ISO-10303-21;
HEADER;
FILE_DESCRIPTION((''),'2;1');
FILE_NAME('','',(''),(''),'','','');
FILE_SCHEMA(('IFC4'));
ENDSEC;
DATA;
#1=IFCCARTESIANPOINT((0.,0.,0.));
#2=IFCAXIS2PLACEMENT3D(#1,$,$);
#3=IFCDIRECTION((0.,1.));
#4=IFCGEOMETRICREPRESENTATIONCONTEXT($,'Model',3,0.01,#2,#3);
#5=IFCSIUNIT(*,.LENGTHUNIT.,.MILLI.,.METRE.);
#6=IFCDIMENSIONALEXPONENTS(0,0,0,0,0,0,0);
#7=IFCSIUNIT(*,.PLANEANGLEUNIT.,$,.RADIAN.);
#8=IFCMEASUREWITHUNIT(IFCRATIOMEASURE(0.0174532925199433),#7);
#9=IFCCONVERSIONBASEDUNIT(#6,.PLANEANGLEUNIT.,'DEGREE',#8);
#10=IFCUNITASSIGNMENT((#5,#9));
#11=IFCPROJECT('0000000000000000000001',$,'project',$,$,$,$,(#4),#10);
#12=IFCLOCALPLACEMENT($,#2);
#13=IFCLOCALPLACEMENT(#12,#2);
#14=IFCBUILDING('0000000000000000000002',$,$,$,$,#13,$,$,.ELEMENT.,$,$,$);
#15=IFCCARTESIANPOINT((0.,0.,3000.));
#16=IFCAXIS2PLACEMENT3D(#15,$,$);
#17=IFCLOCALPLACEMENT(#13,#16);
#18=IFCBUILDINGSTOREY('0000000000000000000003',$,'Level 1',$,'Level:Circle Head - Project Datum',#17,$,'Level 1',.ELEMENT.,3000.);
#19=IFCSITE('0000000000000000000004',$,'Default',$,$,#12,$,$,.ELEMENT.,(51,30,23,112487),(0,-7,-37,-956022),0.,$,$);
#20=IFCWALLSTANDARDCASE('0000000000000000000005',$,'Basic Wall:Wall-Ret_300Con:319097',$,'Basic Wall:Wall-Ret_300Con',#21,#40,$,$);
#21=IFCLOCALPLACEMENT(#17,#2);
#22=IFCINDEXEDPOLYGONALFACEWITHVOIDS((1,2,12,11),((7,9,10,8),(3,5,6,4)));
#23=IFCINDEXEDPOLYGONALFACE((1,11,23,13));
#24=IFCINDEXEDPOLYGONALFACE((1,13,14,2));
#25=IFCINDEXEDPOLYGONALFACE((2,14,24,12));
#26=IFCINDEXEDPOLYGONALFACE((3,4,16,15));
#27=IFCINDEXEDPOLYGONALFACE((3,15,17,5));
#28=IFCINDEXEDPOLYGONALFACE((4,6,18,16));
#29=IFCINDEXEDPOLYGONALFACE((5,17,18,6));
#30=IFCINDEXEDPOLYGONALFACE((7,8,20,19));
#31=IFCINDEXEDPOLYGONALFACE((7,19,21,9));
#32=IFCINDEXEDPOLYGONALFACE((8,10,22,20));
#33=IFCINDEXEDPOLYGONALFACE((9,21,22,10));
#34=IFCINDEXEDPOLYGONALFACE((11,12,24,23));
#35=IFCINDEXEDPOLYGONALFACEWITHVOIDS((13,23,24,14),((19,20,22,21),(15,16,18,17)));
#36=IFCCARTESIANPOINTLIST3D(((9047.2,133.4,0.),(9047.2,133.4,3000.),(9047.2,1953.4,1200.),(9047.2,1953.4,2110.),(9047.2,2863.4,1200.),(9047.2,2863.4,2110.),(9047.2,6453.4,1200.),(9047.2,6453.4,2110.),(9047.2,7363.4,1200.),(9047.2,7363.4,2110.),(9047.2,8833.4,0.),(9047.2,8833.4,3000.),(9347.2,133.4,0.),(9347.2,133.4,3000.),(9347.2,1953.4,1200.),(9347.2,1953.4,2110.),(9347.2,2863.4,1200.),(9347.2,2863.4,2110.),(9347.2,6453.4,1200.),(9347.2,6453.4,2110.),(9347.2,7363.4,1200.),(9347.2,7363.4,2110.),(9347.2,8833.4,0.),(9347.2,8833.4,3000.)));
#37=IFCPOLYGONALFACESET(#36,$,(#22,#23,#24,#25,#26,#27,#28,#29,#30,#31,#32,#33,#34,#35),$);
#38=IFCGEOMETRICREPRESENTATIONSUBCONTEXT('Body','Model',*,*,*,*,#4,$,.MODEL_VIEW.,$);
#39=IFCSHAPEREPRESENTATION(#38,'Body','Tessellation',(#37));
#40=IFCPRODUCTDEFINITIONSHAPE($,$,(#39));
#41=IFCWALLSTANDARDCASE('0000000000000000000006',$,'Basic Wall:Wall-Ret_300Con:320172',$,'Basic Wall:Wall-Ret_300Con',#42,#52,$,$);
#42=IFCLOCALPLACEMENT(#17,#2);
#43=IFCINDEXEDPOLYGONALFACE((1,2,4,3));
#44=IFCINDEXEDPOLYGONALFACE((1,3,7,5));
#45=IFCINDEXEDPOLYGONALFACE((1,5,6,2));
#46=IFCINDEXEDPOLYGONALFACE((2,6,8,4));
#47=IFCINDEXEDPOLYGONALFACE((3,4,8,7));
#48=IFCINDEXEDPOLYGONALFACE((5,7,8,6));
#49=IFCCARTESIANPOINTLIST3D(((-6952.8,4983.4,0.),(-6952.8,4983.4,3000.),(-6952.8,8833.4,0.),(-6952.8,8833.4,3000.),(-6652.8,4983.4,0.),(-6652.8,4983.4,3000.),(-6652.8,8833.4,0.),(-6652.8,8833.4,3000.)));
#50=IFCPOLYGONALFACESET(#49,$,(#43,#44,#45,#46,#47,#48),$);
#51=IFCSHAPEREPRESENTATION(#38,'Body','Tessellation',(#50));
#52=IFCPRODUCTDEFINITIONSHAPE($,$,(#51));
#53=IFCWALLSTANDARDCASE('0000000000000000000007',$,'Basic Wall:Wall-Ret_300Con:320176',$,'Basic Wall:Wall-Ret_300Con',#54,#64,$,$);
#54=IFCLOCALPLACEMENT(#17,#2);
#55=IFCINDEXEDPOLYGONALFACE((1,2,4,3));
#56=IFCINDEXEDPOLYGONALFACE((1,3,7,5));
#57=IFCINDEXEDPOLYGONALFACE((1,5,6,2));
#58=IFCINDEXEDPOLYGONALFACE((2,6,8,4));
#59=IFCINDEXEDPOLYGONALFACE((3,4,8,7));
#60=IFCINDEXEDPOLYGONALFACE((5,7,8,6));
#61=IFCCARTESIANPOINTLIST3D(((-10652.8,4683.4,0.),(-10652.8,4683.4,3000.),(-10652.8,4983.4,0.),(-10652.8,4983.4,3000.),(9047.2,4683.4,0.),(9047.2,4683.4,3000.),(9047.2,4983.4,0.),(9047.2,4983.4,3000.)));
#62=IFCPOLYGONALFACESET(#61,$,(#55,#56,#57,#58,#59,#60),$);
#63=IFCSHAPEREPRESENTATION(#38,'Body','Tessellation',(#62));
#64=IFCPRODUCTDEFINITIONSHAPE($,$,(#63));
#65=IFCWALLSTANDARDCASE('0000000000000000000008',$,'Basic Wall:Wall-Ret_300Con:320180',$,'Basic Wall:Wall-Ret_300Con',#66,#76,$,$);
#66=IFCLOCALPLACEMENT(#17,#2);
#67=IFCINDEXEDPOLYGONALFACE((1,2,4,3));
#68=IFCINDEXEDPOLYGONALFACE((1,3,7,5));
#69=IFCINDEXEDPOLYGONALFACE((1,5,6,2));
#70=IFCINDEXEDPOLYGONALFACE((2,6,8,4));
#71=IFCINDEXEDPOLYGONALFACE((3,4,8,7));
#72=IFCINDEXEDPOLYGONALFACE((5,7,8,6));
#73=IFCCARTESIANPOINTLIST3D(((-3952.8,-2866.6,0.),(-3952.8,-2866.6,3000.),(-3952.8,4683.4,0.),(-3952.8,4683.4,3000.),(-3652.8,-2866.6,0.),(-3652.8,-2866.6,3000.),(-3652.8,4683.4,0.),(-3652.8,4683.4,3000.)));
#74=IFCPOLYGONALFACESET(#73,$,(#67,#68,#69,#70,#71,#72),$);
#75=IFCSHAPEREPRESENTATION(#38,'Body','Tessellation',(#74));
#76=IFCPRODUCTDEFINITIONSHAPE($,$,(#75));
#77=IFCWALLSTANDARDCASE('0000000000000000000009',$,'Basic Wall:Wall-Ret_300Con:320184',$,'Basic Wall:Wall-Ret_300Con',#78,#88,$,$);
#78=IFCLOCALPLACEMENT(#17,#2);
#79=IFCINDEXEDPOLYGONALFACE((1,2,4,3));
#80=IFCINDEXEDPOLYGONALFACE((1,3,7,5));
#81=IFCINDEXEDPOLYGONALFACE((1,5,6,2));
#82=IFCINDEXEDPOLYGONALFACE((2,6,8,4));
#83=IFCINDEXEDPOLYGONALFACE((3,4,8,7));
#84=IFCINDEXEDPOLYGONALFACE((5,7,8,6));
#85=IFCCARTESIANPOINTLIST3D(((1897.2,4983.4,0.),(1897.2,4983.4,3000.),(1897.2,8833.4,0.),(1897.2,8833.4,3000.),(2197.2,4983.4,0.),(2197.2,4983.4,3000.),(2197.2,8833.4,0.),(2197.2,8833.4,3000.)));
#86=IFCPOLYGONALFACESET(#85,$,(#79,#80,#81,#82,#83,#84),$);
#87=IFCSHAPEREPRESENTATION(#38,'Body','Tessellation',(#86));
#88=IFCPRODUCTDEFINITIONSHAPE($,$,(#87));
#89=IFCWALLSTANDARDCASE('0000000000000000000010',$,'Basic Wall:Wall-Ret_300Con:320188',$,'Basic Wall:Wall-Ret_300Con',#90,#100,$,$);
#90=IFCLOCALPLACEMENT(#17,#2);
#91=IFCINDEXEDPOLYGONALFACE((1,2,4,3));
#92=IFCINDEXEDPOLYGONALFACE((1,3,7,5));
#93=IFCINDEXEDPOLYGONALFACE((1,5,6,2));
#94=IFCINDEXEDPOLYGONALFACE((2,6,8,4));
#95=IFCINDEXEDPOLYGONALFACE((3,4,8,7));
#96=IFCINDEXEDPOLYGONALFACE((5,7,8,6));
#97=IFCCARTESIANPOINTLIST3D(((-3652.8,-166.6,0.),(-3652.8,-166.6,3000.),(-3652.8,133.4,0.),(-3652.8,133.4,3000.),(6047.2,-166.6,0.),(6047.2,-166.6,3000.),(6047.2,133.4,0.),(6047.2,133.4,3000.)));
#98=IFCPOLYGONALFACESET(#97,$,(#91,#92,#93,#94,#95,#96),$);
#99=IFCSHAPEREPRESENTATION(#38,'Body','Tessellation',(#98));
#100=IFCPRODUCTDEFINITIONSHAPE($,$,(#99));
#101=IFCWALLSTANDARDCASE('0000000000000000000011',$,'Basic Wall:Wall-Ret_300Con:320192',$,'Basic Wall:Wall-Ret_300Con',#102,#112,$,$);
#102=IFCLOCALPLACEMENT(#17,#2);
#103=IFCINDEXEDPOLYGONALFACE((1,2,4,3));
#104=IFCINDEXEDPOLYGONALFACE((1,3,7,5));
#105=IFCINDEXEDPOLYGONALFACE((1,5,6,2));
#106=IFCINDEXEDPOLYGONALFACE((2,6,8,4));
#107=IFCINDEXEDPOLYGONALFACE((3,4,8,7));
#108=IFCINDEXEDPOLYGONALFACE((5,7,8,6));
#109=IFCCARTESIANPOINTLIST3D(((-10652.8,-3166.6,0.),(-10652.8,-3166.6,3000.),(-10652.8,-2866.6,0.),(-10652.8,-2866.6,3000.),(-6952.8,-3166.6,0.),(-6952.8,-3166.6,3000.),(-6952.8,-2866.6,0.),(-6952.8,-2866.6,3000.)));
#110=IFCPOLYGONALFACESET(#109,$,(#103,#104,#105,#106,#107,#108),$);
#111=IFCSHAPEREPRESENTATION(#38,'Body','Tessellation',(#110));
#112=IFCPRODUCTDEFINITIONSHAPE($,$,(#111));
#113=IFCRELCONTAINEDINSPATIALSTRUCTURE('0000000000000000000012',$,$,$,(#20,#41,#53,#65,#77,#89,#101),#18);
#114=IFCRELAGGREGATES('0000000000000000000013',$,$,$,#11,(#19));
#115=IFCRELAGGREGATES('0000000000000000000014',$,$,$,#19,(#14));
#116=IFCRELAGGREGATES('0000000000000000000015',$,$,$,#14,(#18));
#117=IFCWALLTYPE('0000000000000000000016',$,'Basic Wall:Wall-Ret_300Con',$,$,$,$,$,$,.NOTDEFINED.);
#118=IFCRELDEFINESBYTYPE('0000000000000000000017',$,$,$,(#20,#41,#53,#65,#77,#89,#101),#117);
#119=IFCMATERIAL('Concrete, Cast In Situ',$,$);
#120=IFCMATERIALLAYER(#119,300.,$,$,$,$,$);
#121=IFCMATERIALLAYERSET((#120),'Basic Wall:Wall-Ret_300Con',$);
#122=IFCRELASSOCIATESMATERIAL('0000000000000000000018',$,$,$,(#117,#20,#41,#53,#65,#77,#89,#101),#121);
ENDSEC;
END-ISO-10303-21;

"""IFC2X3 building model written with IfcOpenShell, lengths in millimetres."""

from ifc_helpers import new_model, entity, si_unit, converted_unit, direction, frame, frame_2d, origin, place, context, subcontext, project, spatial, rectangle, extrude, material, layer, layer_set, layer_usage, type_object, element, save


model = new_model("IFC2X3")

# Units and contexts
model_context = context("Model", 3, precision=0.01, world=origin(), true_north=direction((0.0, 1.0)))
body_context = subcontext(model_context, "Body", "Model", "MODEL_VIEW")
ifc_project = project(units=[si_unit("LENGTHUNIT", "METRE", prefix="MILLI"), converted_unit("PLANEANGLEUNIT", "DEGREE", entity("IfcRatioMeasure", 0.0174532925199433), si_unit("PLANEANGLEUNIT", "RADIAN"), dimensions=[0, 0, 0, 0, 0, 0, 0])], contexts=[model_context])

# Site, building, storey
site_placement = place(None, origin())
site = spatial("IfcSite", under=ifc_project, at=site_placement, Name="Default", CompositionType="ELEMENT", RefLatitude=(51, 30, 23, 112487), RefLongitude=(0, -7, -37, -956022), RefElevation=0.0)
building_placement = place(site_placement, origin())
building = spatial("IfcBuilding", under=site, at=building_placement, CompositionType="ELEMENT")
storey_placement = place(building_placement, frame((0.0, 0.0, 3000.0)))
storey = spatial("IfcBuildingStorey", under=building, at=storey_placement, Name="Level 1", ObjectType="Level:Circle Head - Project Datum", LongName="Level 1", CompositionType="ELEMENT", Elevation=3000.0)

# Shared definitions
ifc_material_1 = material(Name="Concrete, Cast In Situ")
ifc_layer_1 = layer(ifc_material_1, 300.0)
ifc_layer_set_1 = layer_set([ifc_layer_1], Name="Basic Wall:Wall-Ret_300Con")
wall_type = type_object("IfcWallType", Name="Basic Wall:Wall-Ret_300Con", PredefinedType="NOTDEFINED", material=ifc_layer_set_1)

# Wall, openings
ifc_layer_usage_1 = layer_usage(ifc_layer_set_1, "AXIS2", "NEGATIVE", 150.0)
wall_1_placement = place(storey_placement, frame((9197.2, 8833.4, 0.0), z_axis=(0.0, 0.0, 1.0), x_axis=(0.0, -1.0, 0.0)))
wall_1 = element("IfcWallStandardCase", 1, at=wall_1_placement, inside=storey, type_object=wall_type, material=ifc_layer_usage_1, Name="Basic Wall:Wall-Ret_300Con:319097", ObjectType="Basic Wall:Wall-Ret_300Con", context=body_context, shape_type="SweptSolid", body=[
    extrude(rectangle(XDim=8700.0, YDim=300.0, at=frame_2d((4350.0, 0.0), x_axis=(-1.0, 0.0))), origin(), (0.0, 0.0, 1.0), 3000.0),
])
opening_1_placement = place(wall_1_placement, frame((5970.0, -150.0, 1200.0)))
element("IfcOpeningElement", 2, at=opening_1_placement, cuts=wall_1, ObjectType="Opening", context=body_context, shape_type="SweptSolid", body=[
    extrude(rectangle(XDim=910.0, YDim=910.0, at=frame_2d((455.0, 455.0), x_axis=(-1.0, 0.0))), frame((0.0, 0.0, 0.0), z_axis=(0.0, 1.0, 0.0), x_axis=(0.0, 0.0, 1.0)), (0.0, 0.0, 1.0), 300.0),
])
opening_2_placement = place(wall_1_placement, frame((2380.0, 150.0, 1200.0)))
element("IfcOpeningElement", 3, at=opening_2_placement, cuts=wall_1, ObjectType="Opening", context=body_context, shape_type="SweptSolid", body=[
    extrude(rectangle(XDim=910.0, YDim=910.0, at=frame_2d((455.0, 455.0), x_axis=(-1.0, 0.0))), frame((0.0, 0.0, 0.0), z_axis=(0.0, -1.0, 0.0), x_axis=(0.0, 0.0, 1.0)), (0.0, 0.0, 1.0), 300.0),
])

# Walls
ifc_layer_usage_2 = layer_usage(ifc_layer_set_1, "AXIS2", "NEGATIVE", 150.0)
wall_2_placement = place(storey_placement, frame((-6802.8, 4983.4, 0.0), z_axis=(0.0, 0.0, 1.0), x_axis=(0.0, 1.0, 0.0)))
element("IfcWallStandardCase", 4, at=wall_2_placement, inside=storey, type_object=wall_type, material=ifc_layer_usage_2, Name="Basic Wall:Wall-Ret_300Con:320172", ObjectType="Basic Wall:Wall-Ret_300Con", context=body_context, shape_type="SweptSolid", body=[
    extrude(rectangle(XDim=3850.0, YDim=300.0, at=frame_2d((1925.0, 0.0), x_axis=(-1.0, 0.0))), origin(), (0.0, 0.0, 1.0), 3000.0),
])
ifc_layer_usage_3 = layer_usage(ifc_layer_set_1, "AXIS2", "NEGATIVE", 150.0)
wall_3_placement = place(storey_placement, frame((-10652.8, 4833.4, 0.0)))
element("IfcWallStandardCase", 5, at=wall_3_placement, inside=storey, type_object=wall_type, material=ifc_layer_usage_3, Name="Basic Wall:Wall-Ret_300Con:320176", ObjectType="Basic Wall:Wall-Ret_300Con", context=body_context, shape_type="SweptSolid", body=[
    extrude(rectangle(XDim=19700.0, YDim=300.0, at=frame_2d((9850.0, 0.0), x_axis=(-1.0, 0.0))), origin(), (0.0, 0.0, 1.0), 3000.0),
])
ifc_layer_usage_4 = layer_usage(ifc_layer_set_1, "AXIS2", "NEGATIVE", 150.0)
wall_4_placement = place(storey_placement, frame((-3802.8, 4683.4, 0.0), z_axis=(0.0, 0.0, 1.0), x_axis=(0.0, -1.0, 0.0)))
element("IfcWallStandardCase", 6, at=wall_4_placement, inside=storey, type_object=wall_type, material=ifc_layer_usage_4, Name="Basic Wall:Wall-Ret_300Con:320180", ObjectType="Basic Wall:Wall-Ret_300Con", context=body_context, shape_type="SweptSolid", body=[
    extrude(rectangle(XDim=7550.0, YDim=300.0, at=frame_2d((3775.0, 0.0), x_axis=(-1.0, 0.0))), origin(), (0.0, 0.0, 1.0), 3000.0),
])
ifc_layer_usage_5 = layer_usage(ifc_layer_set_1, "AXIS2", "NEGATIVE", 150.0)
wall_5_placement = place(storey_placement, frame((2047.2, 4983.4, 0.0), z_axis=(0.0, 0.0, 1.0), x_axis=(0.0, 1.0, 0.0)))
element("IfcWallStandardCase", 7, at=wall_5_placement, inside=storey, type_object=wall_type, material=ifc_layer_usage_5, Name="Basic Wall:Wall-Ret_300Con:320184", ObjectType="Basic Wall:Wall-Ret_300Con", context=body_context, shape_type="SweptSolid", body=[
    extrude(rectangle(XDim=3850.0, YDim=300.0, at=frame_2d((1925.0, 0.0), x_axis=(-1.0, 0.0))), origin(), (0.0, 0.0, 1.0), 3000.0),
])
ifc_layer_usage_6 = layer_usage(ifc_layer_set_1, "AXIS2", "NEGATIVE", 150.0)
wall_6_placement = place(storey_placement, frame((6047.2, -16.6, 0.0), z_axis=(0.0, 0.0, 1.0), x_axis=(-1.0, 0.0, 0.0)))
element("IfcWallStandardCase", 8, at=wall_6_placement, inside=storey, type_object=wall_type, material=ifc_layer_usage_6, Name="Basic Wall:Wall-Ret_300Con:320188", ObjectType="Basic Wall:Wall-Ret_300Con", context=body_context, shape_type="SweptSolid", body=[
    extrude(rectangle(XDim=9700.0, YDim=300.0, at=frame_2d((4850.0, 0.0), x_axis=(-1.0, 0.0))), origin(), (0.0, 0.0, 1.0), 3000.0),
])
ifc_layer_usage_7 = layer_usage(ifc_layer_set_1, "AXIS2", "NEGATIVE", 150.0)
wall_7_placement = place(storey_placement, frame((-6952.8, -3016.6, 0.0), z_axis=(0.0, 0.0, 1.0), x_axis=(-1.0, 0.0, 0.0)))
element("IfcWallStandardCase", 9, at=wall_7_placement, inside=storey, type_object=wall_type, material=ifc_layer_usage_7, Name="Basic Wall:Wall-Ret_300Con:320192", ObjectType="Basic Wall:Wall-Ret_300Con", context=body_context, shape_type="SweptSolid", body=[
    extrude(rectangle(XDim=3700.0, YDim=300.0, at=frame_2d((1850.0, 0.0), x_axis=(-1.0, 0.0))), origin(), (0.0, 0.0, 1.0), 3000.0),
])

save(model, "model.ifc")
